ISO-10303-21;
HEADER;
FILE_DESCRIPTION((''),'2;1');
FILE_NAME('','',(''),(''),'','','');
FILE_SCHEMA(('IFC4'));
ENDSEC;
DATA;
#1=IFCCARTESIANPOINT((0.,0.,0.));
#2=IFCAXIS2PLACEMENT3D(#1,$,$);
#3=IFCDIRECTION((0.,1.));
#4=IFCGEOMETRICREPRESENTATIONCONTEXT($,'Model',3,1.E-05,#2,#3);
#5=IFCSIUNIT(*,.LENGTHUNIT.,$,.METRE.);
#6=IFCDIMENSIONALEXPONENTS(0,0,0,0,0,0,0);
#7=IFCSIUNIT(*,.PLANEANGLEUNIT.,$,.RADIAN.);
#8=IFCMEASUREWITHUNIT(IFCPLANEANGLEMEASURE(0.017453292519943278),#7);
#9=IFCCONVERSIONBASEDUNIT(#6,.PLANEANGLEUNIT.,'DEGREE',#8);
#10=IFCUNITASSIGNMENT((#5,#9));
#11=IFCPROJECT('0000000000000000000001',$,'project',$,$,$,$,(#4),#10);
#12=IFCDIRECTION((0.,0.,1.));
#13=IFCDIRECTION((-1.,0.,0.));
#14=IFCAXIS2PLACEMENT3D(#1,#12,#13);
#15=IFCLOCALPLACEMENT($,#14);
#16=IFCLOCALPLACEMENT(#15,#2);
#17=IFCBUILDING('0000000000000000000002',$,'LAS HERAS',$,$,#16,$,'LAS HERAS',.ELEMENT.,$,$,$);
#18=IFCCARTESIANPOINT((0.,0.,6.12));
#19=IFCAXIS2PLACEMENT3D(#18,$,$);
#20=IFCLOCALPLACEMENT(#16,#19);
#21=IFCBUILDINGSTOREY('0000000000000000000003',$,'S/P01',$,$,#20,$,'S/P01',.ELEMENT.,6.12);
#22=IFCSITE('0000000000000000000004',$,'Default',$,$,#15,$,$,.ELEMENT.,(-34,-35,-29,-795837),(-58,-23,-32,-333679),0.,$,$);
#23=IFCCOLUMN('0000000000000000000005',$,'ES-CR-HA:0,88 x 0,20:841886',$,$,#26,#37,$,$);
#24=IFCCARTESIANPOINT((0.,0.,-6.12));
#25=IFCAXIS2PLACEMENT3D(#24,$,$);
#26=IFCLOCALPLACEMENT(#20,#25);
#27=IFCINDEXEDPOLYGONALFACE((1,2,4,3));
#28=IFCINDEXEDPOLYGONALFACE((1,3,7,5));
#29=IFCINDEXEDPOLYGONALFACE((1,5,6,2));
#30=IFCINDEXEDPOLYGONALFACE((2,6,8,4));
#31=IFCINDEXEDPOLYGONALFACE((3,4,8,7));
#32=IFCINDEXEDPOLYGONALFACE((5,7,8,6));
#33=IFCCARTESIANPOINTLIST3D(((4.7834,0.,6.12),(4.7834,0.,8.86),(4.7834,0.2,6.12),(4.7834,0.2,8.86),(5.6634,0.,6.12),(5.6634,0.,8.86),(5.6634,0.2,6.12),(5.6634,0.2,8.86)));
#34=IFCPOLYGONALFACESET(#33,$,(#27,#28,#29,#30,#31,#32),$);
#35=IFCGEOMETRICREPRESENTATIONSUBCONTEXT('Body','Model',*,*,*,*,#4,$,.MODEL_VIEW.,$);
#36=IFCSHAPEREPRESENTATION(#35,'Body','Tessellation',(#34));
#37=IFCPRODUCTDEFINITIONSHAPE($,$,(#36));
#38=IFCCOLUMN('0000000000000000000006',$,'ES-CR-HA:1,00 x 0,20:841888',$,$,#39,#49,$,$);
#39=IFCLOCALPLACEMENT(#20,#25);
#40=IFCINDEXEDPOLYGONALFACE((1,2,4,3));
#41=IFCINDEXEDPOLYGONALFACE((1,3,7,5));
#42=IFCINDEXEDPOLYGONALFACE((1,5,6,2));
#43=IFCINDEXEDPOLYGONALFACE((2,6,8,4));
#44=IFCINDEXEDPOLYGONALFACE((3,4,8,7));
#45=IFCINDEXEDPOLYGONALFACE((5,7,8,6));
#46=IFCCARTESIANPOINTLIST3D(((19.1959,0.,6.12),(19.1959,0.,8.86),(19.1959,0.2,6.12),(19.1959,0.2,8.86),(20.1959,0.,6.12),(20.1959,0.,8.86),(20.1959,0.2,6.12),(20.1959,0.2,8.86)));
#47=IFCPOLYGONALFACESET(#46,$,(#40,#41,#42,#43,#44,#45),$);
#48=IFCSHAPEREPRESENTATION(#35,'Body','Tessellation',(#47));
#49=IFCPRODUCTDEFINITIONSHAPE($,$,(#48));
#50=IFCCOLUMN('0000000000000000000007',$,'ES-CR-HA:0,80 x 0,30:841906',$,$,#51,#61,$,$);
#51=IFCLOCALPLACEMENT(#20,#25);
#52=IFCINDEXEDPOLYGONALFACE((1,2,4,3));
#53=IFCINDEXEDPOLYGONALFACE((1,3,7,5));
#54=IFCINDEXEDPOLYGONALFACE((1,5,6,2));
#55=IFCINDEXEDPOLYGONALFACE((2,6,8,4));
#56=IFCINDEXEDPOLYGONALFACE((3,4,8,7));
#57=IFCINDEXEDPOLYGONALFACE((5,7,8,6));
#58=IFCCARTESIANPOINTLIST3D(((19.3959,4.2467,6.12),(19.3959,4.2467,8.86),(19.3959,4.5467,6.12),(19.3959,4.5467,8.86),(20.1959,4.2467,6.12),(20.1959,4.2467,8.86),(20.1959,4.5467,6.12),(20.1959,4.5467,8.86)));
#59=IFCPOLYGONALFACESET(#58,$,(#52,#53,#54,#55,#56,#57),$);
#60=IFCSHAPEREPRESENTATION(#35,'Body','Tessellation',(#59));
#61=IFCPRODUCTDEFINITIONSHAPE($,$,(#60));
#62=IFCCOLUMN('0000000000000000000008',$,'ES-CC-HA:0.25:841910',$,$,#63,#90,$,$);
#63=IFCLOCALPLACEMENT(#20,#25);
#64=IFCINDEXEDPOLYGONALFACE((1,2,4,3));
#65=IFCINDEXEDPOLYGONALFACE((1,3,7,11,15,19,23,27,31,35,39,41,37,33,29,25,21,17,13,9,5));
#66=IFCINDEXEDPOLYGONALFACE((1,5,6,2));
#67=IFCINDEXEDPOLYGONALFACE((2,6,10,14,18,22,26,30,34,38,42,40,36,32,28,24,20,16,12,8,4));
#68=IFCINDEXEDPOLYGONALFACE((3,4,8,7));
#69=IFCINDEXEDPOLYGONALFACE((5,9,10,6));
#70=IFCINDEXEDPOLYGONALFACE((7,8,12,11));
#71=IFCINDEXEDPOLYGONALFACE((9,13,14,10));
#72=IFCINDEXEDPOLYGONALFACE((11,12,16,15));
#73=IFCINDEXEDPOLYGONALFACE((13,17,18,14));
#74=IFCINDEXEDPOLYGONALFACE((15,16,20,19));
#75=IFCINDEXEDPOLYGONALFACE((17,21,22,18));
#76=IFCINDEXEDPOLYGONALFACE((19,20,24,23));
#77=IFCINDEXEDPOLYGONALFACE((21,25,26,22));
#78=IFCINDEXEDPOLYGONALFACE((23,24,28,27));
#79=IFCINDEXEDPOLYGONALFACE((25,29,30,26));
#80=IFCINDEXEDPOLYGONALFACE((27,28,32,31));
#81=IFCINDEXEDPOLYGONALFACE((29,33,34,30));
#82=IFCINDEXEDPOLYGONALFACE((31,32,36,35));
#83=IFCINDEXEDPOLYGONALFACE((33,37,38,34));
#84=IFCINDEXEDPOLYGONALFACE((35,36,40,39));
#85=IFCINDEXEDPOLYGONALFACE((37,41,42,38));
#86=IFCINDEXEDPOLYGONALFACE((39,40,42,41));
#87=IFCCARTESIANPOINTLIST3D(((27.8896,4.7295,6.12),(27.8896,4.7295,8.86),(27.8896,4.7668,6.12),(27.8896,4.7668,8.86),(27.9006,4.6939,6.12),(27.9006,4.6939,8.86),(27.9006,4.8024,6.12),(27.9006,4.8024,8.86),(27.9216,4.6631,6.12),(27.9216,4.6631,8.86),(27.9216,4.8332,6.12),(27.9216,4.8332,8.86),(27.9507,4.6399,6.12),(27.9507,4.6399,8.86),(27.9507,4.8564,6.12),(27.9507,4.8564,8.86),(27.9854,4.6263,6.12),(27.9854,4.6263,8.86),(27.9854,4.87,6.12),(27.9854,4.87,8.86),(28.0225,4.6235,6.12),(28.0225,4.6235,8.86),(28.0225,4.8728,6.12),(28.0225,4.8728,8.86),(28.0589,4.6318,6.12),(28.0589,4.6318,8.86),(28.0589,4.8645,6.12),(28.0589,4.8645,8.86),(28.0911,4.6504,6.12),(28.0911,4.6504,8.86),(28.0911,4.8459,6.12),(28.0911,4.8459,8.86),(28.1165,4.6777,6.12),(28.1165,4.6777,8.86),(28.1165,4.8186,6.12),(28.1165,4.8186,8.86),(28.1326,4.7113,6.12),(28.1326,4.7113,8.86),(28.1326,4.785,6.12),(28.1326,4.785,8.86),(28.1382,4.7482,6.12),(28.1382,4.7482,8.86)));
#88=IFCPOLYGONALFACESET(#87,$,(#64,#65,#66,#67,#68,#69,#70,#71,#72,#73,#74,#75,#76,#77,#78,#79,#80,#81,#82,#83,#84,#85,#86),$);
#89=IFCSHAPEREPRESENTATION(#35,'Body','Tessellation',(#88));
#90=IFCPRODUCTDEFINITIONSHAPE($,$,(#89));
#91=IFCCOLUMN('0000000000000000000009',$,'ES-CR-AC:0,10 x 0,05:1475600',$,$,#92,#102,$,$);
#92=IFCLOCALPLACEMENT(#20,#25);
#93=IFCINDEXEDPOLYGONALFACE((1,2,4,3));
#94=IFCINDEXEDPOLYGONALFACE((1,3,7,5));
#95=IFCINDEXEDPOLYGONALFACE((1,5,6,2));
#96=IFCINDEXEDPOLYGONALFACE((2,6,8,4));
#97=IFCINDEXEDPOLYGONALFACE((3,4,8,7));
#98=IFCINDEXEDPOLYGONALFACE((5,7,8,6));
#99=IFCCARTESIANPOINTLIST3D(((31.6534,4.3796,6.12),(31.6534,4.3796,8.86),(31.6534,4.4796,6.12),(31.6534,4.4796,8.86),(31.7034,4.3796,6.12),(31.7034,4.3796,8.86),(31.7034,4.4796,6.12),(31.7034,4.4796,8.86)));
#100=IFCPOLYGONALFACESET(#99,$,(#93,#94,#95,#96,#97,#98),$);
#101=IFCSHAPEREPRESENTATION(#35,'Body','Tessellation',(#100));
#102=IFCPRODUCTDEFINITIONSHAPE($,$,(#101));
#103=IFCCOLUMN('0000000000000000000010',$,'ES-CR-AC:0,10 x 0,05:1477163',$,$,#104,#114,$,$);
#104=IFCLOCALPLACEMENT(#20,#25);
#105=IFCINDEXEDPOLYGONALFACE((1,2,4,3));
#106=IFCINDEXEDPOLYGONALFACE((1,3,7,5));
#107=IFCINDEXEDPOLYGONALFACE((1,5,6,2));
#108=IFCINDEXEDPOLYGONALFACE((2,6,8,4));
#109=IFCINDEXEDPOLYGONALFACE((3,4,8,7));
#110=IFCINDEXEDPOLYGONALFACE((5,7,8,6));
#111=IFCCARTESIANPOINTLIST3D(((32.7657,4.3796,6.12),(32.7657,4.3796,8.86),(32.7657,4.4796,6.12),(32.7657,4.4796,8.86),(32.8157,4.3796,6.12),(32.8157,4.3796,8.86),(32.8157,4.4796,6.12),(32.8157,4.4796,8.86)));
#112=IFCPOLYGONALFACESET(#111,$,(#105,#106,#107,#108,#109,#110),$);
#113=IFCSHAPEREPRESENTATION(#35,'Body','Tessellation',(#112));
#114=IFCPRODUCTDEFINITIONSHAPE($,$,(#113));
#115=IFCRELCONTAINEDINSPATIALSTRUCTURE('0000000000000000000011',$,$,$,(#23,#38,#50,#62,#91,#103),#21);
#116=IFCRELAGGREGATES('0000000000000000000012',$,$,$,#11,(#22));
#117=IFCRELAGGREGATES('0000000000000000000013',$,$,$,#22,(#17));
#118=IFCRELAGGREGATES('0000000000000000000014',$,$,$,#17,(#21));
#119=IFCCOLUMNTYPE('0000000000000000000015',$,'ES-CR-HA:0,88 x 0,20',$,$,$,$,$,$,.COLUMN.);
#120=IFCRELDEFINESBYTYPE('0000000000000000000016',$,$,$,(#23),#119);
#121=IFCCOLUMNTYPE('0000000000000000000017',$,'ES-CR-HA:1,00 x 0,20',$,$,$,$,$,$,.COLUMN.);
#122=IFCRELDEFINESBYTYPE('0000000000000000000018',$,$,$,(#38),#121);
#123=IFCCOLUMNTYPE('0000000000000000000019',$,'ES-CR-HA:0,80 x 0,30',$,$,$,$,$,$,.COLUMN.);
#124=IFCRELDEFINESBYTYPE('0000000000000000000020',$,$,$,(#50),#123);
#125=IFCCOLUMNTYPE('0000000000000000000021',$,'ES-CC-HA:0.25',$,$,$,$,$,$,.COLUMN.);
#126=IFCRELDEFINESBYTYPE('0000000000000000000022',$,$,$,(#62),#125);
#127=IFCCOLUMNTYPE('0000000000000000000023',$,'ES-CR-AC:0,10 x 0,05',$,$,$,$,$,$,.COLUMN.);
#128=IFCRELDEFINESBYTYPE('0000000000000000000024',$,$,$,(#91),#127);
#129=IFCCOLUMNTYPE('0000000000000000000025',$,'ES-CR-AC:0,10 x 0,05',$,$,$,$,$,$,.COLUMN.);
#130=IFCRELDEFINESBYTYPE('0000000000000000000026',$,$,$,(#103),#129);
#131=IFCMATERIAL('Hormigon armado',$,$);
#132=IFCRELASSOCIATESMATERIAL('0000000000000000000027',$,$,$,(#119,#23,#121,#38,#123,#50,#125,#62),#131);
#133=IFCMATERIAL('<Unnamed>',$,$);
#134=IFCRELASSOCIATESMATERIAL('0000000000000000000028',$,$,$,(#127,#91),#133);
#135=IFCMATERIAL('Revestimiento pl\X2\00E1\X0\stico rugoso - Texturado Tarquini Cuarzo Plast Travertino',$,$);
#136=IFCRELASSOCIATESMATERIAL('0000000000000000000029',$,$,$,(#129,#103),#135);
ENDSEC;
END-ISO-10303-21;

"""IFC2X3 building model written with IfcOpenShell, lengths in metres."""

from ifc_helpers import new_model, entity, si_unit, converted_unit, direction, frame, frame_2d, origin, origin_2d_with_axis, place, context, subcontext, project, spatial, rectangle, circle, extrude, source, transform, mapped, material, type_object, type_shapes, element, save


model = new_model("IFC2X3")

# Units and contexts
model_context = context("Model", 3, precision=1e-05, world=origin(), true_north=direction((0.0, 1.0)))
body_context = subcontext(model_context, "Body", "Model", "MODEL_VIEW")
ifc_project = project(units=[si_unit("LENGTHUNIT", "METRE"), converted_unit("PLANEANGLEUNIT", "DEGREE", entity("IfcPlaneAngleMeasure", 0.017453292519943278), si_unit("PLANEANGLEUNIT", "RADIAN"), dimensions=[0, 0, 0, 0, 0, 0, 0])], contexts=[model_context])

# Site, building, storey
site_placement = place(None, frame((0.0, 0.0, 0.0), z_axis=(0.0, 0.0, 1.0), x_axis=(-1.0, 0.0, 0.0)))
site = spatial("IfcSite", under=ifc_project, at=site_placement, Name="Default", CompositionType="ELEMENT", RefLatitude=(-34, -35, -29, -795837), RefLongitude=(-58, -23, -32, -333679), RefElevation=0.0)
building_placement = place(site_placement, origin())
building = spatial("IfcBuilding", under=site, at=building_placement, Name="LAS HERAS", LongName="LAS HERAS", CompositionType="ELEMENT")
storey_placement = place(building_placement, frame((0.0, 0.0, 6.12)))
storey = spatial("IfcBuildingStorey", under=building, at=storey_placement, Name="S/P01", LongName="S/P01", CompositionType="ELEMENT", Elevation=6.12)

# Columns
ifc_material_1 = material(Name="Hormigon armado")
column_type_1 = type_object("IfcColumnType", Name="ES-CR-HA:0,88 x 0,20", PredefinedType="COLUMN", material=ifc_material_1)
shared_shape_1 = source(origin(), body_context, "Body", "SweptSolid", [
    extrude(rectangle(XDim=2.74, YDim=0.2, at=frame_2d((0.0, 0.0), x_axis=(1.0, 0.0))), frame((4.7834, 0.1, 7.49), z_axis=(1.0, 0.0, 0.0), x_axis=(0.0, 0.0, 1.0)), (0.0, 0.0, 1.0), 0.88),
])
type_shapes(column_type_1, [shared_shape_1])
column_1_placement = place(storey_placement, frame((0.0, 0.0, -6.12)))
element("IfcColumn", 1, at=column_1_placement, inside=storey, type_object=column_type_1, material=ifc_material_1, Name="ES-CR-HA:0,88 x 0,20:841886", context=body_context, shape_type="MappedRepresentation", body=[
    mapped(shared_shape_1, transform((0.0, 0.0, 0.0), scale=1.0)),
])
column_type_2 = type_object("IfcColumnType", Name="ES-CR-HA:1,00 x 0,20", PredefinedType="COLUMN", material=ifc_material_1)
shared_shape_2 = source(origin(), body_context, "Body", "SweptSolid", [
    extrude(rectangle(XDim=2.74, YDim=0.2, at=frame_2d((0.0, 0.0), x_axis=(1.0, 0.0))), frame((19.1959, 0.1, 7.49), z_axis=(1.0, 0.0, 0.0), x_axis=(0.0, 0.0, 1.0)), (0.0, 0.0, 1.0), 1.0),
])
type_shapes(column_type_2, [shared_shape_2])
column_2_placement = place(storey_placement, frame((0.0, 0.0, -6.12)))
element("IfcColumn", 2, at=column_2_placement, inside=storey, type_object=column_type_2, material=ifc_material_1, Name="ES-CR-HA:1,00 x 0,20:841888", context=body_context, shape_type="MappedRepresentation", body=[
    mapped(shared_shape_2, transform((0.0, 0.0, 0.0), scale=1.0)),
])
column_type_3 = type_object("IfcColumnType", Name="ES-CR-HA:0,80 x 0,30", PredefinedType="COLUMN", material=ifc_material_1)
shared_shape_3 = source(origin(), body_context, "Body", "SweptSolid", [
    extrude(rectangle(XDim=2.74, YDim=0.3, at=frame_2d((0.0, 0.0), x_axis=(1.0, 0.0))), frame((19.3959, 4.3967, 7.49), z_axis=(1.0, 0.0, 0.0), x_axis=(0.0, 0.0, 1.0)), (0.0, 0.0, 1.0), 0.8),
])
type_shapes(column_type_3, [shared_shape_3])
column_3_placement = place(storey_placement, frame((0.0, 0.0, -6.12)))
element("IfcColumn", 3, at=column_3_placement, inside=storey, type_object=column_type_3, material=ifc_material_1, Name="ES-CR-HA:0,80 x 0,30:841906", context=body_context, shape_type="MappedRepresentation", body=[
    mapped(shared_shape_3, transform((0.0, 0.0, 0.0), scale=1.0)),
])
column_type_4 = type_object("IfcColumnType", Name="ES-CC-HA:0.25", PredefinedType="COLUMN", material=ifc_material_1)
shared_shape_4 = source(origin(), body_context, "Body", "SweptSolid", [
    extrude(circle(Radius=0.125, at=origin_2d_with_axis()), frame((28.0132, 4.7482, 6.12)), (0.0, 0.0, 1.0), 2.74),
])
type_shapes(column_type_4, [shared_shape_4])
column_4_placement = place(storey_placement, frame((0.0, 0.0, -6.12)))
element("IfcColumn", 4, at=column_4_placement, inside=storey, type_object=column_type_4, material=ifc_material_1, Name="ES-CC-HA:0.25:841910", context=body_context, shape_type="MappedRepresentation", body=[
    mapped(shared_shape_4, transform((0.0, 0.0, 0.0), scale=1.0)),
])
ifc_material_2 = material(Name="<Unnamed>")
column_type_5 = type_object("IfcColumnType", Name="ES-CR-AC:0,10 x 0,05", PredefinedType="COLUMN", material=ifc_material_2)
shared_shape_5 = source(origin(), body_context, "Body", "SweptSolid", [
    extrude(rectangle(XDim=0.05, YDim=0.1, at=frame_2d((0.0, 0.0), x_axis=(1.0, 0.0))), frame((31.6784, 4.4296, 6.12), z_axis=(0.0, 0.0, 1.0), x_axis=(-1.0, 0.0, 0.0)), (0.0, 0.0, 1.0), 2.74),
])
type_shapes(column_type_5, [shared_shape_5])
column_5_placement = place(storey_placement, frame((0.0, 0.0, -6.12)))
element("IfcColumn", 5, at=column_5_placement, inside=storey, type_object=column_type_5, material=ifc_material_2, Name="ES-CR-AC:0,10 x 0,05:1475600", context=body_context, shape_type="MappedRepresentation", body=[
    mapped(shared_shape_5, transform((0.0, 0.0, 0.0), scale=1.0)),
])
ifc_material_3 = material(Name="Revestimiento plástico rugoso - Texturado Tarquini Cuarzo Plast Travertino")
column_type_6 = type_object("IfcColumnType", Name="ES-CR-AC:0,10 x 0,05", PredefinedType="COLUMN", material=ifc_material_3)
shared_shape_6 = source(origin(), body_context, "Body", "SweptSolid", [
    extrude(rectangle(XDim=0.05, YDim=0.1, at=frame_2d((0.0, 0.0), x_axis=(1.0, 0.0))), frame((32.7907, 4.4296, 6.12), z_axis=(0.0, 0.0, 1.0), x_axis=(-1.0, 0.0, 0.0)), (0.0, 0.0, 1.0), 2.74),
])
type_shapes(column_type_6, [shared_shape_6])
column_6_placement = place(storey_placement, frame((0.0, 0.0, -6.12)))
element("IfcColumn", 6, at=column_6_placement, inside=storey, type_object=column_type_6, material=ifc_material_3, Name="ES-CR-AC:0,10 x 0,05:1477163", context=body_context, shape_type="MappedRepresentation", body=[
    mapped(shared_shape_6, transform((0.0, 0.0, 0.0), scale=1.0)),
])

save(model, "model.ifc")
